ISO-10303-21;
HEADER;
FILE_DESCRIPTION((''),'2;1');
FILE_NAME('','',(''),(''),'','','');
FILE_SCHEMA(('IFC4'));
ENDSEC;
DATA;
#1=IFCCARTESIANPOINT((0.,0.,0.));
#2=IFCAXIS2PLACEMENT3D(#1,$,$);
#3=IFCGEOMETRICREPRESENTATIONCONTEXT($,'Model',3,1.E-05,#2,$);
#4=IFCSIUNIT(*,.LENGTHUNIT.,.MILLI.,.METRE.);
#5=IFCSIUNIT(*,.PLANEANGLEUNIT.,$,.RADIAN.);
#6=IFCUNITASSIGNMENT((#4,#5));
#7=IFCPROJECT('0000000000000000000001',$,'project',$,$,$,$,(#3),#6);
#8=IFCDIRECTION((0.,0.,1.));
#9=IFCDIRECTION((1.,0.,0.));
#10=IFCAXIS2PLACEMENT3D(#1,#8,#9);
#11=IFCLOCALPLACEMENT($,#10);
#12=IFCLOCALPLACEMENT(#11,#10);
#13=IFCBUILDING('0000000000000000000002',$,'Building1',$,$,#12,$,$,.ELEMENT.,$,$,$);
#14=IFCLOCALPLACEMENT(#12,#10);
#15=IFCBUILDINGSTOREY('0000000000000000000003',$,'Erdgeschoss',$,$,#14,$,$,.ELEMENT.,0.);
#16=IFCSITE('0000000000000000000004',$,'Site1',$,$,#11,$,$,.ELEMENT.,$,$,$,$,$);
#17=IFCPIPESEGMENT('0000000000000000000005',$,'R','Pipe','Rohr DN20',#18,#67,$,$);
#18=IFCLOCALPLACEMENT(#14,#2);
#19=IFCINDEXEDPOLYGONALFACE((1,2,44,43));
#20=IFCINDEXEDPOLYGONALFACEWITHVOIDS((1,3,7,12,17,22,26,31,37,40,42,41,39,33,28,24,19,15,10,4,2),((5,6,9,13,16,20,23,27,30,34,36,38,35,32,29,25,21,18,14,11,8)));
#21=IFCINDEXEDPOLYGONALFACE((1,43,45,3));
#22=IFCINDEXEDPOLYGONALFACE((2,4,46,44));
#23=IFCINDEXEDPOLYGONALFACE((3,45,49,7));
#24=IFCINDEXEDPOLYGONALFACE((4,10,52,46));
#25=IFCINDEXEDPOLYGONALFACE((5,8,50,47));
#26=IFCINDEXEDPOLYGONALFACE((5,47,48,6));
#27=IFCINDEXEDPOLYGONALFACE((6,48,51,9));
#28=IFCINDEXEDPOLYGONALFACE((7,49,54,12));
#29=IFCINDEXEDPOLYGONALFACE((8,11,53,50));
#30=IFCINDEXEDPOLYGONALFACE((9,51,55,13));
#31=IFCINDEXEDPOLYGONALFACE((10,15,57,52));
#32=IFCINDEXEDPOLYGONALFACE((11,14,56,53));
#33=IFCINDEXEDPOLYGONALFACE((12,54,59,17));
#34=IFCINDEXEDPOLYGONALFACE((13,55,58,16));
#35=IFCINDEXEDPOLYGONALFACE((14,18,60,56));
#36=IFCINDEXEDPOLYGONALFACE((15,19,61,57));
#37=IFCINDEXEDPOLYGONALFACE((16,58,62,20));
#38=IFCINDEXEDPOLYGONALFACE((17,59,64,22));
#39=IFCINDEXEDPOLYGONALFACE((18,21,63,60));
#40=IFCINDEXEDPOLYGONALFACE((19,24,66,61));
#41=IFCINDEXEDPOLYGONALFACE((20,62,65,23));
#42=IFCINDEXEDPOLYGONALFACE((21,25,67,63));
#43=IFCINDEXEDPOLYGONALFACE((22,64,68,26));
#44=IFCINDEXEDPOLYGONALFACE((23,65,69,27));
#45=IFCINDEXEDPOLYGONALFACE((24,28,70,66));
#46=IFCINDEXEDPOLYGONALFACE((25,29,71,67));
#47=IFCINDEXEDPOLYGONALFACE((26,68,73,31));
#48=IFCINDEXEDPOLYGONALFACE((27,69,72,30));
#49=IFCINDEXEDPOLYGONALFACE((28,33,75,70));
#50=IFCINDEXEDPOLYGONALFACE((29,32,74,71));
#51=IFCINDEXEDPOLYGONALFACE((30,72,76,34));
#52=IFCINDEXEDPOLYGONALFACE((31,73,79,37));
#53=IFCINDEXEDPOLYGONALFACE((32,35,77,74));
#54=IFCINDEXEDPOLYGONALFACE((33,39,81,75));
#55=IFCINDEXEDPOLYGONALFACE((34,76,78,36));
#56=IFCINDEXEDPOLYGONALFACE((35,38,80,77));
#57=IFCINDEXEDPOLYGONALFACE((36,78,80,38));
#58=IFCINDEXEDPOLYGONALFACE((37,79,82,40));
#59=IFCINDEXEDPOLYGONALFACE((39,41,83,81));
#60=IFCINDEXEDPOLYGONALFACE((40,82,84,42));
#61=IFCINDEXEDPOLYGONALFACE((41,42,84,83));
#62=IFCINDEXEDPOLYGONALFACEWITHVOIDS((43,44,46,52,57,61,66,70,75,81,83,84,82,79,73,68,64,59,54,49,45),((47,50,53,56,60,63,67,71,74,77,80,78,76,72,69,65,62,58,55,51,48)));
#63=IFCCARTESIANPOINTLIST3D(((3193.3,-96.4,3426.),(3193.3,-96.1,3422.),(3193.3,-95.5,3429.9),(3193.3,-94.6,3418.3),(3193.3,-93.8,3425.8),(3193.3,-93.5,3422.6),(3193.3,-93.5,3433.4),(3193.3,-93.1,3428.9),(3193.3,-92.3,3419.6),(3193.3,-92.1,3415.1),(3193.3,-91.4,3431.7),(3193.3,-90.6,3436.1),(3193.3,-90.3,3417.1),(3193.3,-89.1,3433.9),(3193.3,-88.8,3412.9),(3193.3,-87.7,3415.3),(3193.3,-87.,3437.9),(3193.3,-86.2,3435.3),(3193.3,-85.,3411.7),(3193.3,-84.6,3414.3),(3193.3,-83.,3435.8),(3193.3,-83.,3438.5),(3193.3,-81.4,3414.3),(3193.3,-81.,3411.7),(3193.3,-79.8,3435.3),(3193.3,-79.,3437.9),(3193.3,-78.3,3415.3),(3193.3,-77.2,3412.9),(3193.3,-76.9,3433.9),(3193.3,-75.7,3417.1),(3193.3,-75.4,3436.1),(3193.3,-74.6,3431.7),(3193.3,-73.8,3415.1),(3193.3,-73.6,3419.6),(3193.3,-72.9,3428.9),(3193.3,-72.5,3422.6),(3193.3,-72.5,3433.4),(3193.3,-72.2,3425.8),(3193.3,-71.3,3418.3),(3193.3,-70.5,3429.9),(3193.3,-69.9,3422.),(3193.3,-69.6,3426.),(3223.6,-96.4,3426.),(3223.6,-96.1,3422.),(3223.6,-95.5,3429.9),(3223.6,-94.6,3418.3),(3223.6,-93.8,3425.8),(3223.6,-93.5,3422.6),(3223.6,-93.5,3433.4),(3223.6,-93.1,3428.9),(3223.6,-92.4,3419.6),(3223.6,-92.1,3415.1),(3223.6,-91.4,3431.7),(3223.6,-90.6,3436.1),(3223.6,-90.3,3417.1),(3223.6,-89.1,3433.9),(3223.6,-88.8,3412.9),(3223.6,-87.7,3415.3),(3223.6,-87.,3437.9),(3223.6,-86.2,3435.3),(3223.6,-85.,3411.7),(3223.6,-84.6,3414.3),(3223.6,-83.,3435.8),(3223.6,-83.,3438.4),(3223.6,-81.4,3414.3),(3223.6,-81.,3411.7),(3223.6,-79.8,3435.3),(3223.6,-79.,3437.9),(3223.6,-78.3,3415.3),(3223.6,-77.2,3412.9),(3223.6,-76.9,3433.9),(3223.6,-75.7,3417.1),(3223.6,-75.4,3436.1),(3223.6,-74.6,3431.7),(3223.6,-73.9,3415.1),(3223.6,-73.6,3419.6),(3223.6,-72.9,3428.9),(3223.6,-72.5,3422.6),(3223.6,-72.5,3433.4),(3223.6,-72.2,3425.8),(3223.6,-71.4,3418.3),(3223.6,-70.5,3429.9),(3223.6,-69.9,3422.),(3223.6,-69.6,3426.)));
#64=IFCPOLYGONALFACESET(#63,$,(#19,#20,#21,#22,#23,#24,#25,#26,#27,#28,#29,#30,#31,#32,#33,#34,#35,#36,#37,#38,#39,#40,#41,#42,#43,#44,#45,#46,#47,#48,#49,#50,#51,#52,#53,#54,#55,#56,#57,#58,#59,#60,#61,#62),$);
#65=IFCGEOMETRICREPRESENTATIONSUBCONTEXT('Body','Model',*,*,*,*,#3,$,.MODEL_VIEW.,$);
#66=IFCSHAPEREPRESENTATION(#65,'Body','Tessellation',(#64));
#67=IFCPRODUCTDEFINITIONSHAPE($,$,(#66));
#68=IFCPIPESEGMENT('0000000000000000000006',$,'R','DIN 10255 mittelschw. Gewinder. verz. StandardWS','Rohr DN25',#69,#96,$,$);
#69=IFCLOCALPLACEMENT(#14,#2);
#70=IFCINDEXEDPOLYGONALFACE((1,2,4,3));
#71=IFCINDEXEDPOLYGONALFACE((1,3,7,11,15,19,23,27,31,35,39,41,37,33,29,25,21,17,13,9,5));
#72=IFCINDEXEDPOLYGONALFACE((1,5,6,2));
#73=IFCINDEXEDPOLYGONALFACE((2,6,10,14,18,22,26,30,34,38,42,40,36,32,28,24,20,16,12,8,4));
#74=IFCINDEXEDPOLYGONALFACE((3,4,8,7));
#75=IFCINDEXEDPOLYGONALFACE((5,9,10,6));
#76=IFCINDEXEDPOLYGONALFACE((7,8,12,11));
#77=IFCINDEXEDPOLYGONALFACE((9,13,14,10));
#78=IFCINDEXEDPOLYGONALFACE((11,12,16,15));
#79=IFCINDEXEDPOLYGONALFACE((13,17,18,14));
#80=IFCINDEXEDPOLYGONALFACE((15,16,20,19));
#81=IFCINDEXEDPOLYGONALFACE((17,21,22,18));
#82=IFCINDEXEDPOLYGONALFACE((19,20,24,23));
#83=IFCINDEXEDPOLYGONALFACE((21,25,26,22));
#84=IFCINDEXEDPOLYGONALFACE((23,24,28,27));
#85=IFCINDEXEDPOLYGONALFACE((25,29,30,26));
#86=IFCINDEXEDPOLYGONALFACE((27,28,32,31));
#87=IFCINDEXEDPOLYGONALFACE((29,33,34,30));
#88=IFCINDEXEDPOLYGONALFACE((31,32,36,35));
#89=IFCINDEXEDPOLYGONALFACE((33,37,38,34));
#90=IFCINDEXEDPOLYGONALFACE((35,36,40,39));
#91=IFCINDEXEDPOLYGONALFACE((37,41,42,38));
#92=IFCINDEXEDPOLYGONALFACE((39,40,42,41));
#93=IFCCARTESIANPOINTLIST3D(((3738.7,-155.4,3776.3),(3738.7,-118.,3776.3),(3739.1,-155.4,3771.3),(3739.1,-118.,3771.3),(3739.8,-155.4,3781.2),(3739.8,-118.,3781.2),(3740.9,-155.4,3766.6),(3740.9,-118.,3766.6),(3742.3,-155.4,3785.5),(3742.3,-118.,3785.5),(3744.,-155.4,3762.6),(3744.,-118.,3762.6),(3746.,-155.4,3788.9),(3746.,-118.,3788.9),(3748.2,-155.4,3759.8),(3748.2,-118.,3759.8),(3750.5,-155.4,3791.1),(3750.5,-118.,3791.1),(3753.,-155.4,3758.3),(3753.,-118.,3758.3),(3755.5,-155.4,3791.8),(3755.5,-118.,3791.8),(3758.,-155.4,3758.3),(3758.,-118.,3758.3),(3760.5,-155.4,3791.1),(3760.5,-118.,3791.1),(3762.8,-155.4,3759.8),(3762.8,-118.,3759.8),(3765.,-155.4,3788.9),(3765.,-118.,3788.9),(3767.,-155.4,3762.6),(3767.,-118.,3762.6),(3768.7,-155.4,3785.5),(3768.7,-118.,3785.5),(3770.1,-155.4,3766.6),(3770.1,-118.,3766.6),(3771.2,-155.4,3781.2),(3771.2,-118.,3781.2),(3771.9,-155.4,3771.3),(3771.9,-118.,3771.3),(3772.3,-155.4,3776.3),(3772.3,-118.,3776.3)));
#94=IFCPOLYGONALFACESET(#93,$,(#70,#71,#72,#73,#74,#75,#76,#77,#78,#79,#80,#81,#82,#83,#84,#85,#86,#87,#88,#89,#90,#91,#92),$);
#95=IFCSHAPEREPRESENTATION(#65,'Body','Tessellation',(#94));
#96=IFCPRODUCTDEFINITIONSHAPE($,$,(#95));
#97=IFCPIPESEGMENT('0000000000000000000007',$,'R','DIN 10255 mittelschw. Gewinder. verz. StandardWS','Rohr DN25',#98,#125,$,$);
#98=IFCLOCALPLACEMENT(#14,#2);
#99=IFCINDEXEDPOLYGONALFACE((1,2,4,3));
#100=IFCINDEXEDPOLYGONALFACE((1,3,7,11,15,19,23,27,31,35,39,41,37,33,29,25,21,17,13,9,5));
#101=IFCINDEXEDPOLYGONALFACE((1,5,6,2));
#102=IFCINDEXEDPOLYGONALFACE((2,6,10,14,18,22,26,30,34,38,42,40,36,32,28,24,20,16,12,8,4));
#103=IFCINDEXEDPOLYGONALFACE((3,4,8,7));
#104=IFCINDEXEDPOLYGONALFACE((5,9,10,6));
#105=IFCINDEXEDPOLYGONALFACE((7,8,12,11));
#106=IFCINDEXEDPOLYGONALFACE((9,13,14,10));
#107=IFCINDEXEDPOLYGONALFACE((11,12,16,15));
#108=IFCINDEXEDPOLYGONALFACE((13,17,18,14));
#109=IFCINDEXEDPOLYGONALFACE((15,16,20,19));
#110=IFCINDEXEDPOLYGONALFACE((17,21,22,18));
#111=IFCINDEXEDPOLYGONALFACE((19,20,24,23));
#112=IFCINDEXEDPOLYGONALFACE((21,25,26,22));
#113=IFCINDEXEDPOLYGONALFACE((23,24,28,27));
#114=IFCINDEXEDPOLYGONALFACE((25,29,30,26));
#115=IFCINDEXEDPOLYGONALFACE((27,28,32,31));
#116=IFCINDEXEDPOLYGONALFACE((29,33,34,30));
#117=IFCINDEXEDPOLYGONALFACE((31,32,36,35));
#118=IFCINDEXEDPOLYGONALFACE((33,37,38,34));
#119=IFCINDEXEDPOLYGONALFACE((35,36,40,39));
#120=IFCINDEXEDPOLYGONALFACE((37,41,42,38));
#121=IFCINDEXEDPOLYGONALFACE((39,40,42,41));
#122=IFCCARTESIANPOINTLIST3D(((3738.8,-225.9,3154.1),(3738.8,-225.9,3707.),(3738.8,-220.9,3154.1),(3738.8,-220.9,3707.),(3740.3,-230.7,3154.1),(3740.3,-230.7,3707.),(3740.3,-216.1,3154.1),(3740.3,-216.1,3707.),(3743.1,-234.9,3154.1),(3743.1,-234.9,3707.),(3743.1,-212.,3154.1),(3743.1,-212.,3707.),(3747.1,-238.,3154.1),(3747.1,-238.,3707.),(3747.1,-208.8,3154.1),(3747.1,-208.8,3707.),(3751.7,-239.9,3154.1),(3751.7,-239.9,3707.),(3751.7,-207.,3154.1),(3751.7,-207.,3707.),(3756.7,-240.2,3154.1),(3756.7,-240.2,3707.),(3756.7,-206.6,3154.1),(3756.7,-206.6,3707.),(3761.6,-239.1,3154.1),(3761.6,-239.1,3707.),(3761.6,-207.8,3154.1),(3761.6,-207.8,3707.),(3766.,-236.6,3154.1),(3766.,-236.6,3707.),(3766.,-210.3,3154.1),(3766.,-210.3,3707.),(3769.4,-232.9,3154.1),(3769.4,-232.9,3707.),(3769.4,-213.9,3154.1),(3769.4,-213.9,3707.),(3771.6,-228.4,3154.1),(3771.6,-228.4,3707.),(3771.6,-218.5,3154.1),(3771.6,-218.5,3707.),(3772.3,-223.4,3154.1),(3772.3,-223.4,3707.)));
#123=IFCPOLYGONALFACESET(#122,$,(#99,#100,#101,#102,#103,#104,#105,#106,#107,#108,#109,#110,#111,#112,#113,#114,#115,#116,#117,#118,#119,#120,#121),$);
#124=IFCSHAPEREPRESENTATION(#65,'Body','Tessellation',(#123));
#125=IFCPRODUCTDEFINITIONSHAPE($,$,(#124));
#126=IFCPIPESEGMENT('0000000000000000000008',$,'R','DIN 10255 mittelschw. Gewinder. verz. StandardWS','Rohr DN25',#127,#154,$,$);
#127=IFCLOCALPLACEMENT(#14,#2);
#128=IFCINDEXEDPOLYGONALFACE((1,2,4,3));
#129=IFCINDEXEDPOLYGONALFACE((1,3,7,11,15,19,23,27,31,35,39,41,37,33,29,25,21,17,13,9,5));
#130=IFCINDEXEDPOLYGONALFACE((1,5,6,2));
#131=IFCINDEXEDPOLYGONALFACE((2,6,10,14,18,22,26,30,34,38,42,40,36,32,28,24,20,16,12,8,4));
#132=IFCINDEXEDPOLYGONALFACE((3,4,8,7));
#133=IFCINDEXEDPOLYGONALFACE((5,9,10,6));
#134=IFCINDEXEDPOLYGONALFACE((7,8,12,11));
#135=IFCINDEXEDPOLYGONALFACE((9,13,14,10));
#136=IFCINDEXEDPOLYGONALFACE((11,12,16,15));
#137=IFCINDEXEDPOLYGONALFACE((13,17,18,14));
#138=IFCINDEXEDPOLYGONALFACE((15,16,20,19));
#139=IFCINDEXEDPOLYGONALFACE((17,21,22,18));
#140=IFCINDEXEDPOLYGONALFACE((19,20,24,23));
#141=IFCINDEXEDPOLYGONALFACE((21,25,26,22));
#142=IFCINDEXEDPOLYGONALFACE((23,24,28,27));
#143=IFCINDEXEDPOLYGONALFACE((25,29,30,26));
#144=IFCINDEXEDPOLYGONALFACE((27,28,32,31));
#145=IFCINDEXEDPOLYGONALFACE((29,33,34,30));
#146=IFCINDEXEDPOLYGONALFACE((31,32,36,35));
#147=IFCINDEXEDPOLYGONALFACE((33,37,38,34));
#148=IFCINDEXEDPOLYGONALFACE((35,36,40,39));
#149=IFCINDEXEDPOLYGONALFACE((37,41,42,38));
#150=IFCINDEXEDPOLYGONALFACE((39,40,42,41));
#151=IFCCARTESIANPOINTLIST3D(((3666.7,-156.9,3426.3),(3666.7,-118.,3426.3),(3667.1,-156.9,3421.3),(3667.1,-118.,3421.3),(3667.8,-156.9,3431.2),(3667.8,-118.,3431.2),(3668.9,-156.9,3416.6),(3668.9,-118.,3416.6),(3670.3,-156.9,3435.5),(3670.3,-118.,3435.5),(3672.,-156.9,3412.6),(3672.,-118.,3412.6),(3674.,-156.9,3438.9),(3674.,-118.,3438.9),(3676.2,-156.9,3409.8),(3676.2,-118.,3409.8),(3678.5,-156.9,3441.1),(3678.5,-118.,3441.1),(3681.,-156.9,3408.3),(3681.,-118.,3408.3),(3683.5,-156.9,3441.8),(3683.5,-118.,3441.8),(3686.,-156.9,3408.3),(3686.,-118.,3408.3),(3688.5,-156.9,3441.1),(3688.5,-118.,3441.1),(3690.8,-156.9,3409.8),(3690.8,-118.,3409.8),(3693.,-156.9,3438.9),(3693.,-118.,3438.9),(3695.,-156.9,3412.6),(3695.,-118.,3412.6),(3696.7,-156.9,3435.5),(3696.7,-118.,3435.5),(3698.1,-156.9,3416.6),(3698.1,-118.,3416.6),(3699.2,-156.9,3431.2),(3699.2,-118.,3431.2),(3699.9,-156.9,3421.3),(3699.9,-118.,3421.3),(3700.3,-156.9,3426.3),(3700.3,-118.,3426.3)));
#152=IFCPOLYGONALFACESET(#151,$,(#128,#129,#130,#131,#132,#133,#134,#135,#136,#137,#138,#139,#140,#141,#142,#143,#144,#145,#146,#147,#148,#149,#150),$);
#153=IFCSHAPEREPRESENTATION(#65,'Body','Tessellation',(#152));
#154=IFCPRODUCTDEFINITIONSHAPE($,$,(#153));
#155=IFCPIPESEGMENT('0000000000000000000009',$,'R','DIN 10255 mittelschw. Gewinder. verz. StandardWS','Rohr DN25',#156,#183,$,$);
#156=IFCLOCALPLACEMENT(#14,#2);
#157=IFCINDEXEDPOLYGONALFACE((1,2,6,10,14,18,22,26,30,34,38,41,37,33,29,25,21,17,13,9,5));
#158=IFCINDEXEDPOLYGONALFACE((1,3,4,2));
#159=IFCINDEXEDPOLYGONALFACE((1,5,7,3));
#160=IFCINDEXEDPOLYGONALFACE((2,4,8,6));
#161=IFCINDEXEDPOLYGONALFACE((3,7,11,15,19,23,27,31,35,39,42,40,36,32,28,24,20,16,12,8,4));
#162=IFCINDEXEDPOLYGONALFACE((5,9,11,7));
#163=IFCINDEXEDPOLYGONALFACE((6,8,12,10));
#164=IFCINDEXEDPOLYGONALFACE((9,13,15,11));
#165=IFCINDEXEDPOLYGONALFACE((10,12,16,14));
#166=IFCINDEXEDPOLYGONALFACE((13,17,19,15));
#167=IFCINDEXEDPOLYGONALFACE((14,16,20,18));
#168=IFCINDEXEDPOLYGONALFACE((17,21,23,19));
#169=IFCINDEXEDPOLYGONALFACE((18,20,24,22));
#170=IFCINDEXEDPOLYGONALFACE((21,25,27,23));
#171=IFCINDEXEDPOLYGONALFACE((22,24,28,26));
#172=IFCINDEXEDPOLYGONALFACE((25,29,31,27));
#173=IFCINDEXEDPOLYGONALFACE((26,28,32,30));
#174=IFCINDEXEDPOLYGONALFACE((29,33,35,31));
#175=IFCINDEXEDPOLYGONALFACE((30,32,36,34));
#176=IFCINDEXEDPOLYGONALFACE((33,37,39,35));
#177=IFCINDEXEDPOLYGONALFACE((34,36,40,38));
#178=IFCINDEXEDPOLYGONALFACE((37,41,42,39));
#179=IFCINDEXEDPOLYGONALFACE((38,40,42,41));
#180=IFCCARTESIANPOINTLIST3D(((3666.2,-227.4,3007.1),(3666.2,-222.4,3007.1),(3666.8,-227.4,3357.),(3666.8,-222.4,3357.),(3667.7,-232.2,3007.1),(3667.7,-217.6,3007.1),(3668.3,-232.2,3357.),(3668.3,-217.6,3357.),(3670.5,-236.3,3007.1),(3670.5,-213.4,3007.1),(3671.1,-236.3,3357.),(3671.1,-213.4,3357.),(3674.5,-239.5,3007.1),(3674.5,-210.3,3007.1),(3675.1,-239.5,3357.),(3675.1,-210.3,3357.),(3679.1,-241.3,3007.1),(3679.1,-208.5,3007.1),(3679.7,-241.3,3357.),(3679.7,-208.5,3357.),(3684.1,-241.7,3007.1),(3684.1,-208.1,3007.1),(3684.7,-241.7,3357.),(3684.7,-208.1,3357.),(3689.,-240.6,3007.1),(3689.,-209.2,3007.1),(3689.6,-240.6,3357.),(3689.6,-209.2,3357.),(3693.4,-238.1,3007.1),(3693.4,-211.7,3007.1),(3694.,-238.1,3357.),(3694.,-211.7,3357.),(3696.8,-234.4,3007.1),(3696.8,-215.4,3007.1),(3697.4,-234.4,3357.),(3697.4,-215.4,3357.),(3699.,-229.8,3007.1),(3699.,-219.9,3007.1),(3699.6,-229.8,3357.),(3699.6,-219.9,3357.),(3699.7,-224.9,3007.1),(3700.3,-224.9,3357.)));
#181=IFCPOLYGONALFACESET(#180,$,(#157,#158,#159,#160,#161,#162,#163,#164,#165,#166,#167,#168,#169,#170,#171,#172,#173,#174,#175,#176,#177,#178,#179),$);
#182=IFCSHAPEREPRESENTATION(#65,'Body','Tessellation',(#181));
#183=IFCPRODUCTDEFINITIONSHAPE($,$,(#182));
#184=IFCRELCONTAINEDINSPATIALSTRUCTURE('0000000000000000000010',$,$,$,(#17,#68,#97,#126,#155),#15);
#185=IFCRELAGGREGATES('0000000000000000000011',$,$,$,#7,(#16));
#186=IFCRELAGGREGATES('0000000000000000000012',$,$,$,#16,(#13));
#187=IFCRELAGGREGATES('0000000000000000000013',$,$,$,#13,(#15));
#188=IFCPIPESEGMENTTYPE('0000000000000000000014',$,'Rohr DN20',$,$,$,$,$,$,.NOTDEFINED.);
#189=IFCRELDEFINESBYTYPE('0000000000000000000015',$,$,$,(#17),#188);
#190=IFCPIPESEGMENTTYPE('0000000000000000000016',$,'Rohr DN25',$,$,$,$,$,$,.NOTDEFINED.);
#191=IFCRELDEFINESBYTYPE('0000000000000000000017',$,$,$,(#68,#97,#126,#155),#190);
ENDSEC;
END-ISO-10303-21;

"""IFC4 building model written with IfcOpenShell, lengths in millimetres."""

from ifc_helpers import new_model, si_unit, frame, origin, origin_with_axes, origin_2d_with_axis, place, context, subcontext, project, spatial, circle, hollow_circle, extrude, type_object, element, save


model = new_model("IFC4")

# Units and contexts
model_context = context("Model", 3, precision=1e-05, world=origin())
body_context = subcontext(model_context, "Body", "Model", "MODEL_VIEW")
ifc_project = project(units=[si_unit("LENGTHUNIT", "METRE", prefix="MILLI"), si_unit("PLANEANGLEUNIT", "RADIAN")], contexts=[model_context])

# Site, building, storey
site_placement = place(None, origin_with_axes())
site = spatial("IfcSite", under=ifc_project, at=site_placement, Name="Site1", CompositionType="ELEMENT")
building_placement = place(site_placement, origin_with_axes())
building = spatial("IfcBuilding", under=site, at=building_placement, Name="Building1", CompositionType="ELEMENT")
storey_placement = place(building_placement, origin_with_axes())
storey = spatial("IfcBuildingStorey", under=building, at=storey_placement, Name="Erdgeschoss", CompositionType="ELEMENT", Elevation=0.0)

# Pipe segments
pipe_segment_type_1 = type_object("IfcPipeSegmentType", Name="Rohr DN20", PredefinedType="NOTDEFINED")
pipe_segment_1_placement = place(storey_placement, frame((3208.4, -82.8, 3425.0), z_axis=(0.0, 0.0, 1.0), x_axis=(1.0, 0.0, 0.0)))
element("IfcPipeSegment", 1, at=pipe_segment_1_placement, inside=storey, type_object=pipe_segment_type_1, Name="R", Description="Pipe", ObjectType="Rohr DN20", context=body_context, shape_type="SolidModel", body=[
    extrude(hollow_circle(Radius=13.4, WallThickness=2.6, at=origin_2d_with_axis()), frame((-15.2, -0.1, 0.0), z_axis=(1.0, -0.000108, -0.000078), x_axis=(0.0, 0.0, 1.0)), (0.0, 0.0, 1.0), 30.3),
])
pipe_segment_type_2 = type_object("IfcPipeSegmentType", Name="Rohr DN25", PredefinedType="NOTDEFINED")
pipe_segment_2_placement = place(storey_placement, frame((3755.6, -136.7, 3775.0), z_axis=(0.0, 0.0, 1.0), x_axis=(1.0, 0.0, 0.0)))
element("IfcPipeSegment", 2, at=pipe_segment_2_placement, inside=storey, type_object=pipe_segment_type_2, Name="R", Description="DIN 10255 mittelschw. Gewinder. verz. StandardWS", ObjectType="Rohr DN25", context=body_context, shape_type="SolidModel", body=[
    extrude(circle(Radius=16.9, at=origin_2d_with_axis()), frame((-0.1, 18.7, 0.0), z_axis=(0.0, -1.0, 0.0), x_axis=(0.0, 0.0, 1.0)), (0.0, 0.0, 1.0), 37.4),
])
pipe_segment_3_placement = place(storey_placement, frame((3755.5, -223.3, 3430.6), z_axis=(0.0, 0.0, 1.0), x_axis=(1.0, 0.0, 0.0)))
element("IfcPipeSegment", 3, at=pipe_segment_3_placement, inside=storey, type_object=pipe_segment_type_2, Name="R", Description="DIN 10255 mittelschw. Gewinder. verz. StandardWS", ObjectType="Rohr DN25", context=body_context, shape_type="SolidModel", body=[
    extrude(circle(Radius=16.9, at=origin_2d_with_axis()), frame((0.0, -0.2, 276.4), z_axis=(0.0, 0.0, -1.0), x_axis=(1.0, 0.0, 0.0)), (0.0, 0.0, 1.0), 552.9),
])
pipe_segment_4_placement = place(storey_placement, frame((3683.6, -137.4, 3425.0), z_axis=(0.0, 0.0, 1.0), x_axis=(1.0, 0.0, 0.0)))
element("IfcPipeSegment", 4, at=pipe_segment_4_placement, inside=storey, type_object=pipe_segment_type_2, Name="R", Description="DIN 10255 mittelschw. Gewinder. verz. StandardWS", ObjectType="Rohr DN25", context=body_context, shape_type="SolidModel", body=[
    extrude(circle(Radius=16.9, at=origin_2d_with_axis()), frame((-0.2, 19.4, 0.0), z_axis=(0.0, -1.0, 0.0), x_axis=(0.0, 0.0, 1.0)), (0.0, 0.0, 1.0), 38.9),
])
pipe_segment_5_placement = place(storey_placement, frame((3683.2, -225.0, 3182.1), z_axis=(0.0, 0.0, 1.0), x_axis=(1.0, 0.0, 0.0)))
element("IfcPipeSegment", 5, at=pipe_segment_5_placement, inside=storey, type_object=pipe_segment_type_2, Name="R", Description="DIN 10255 mittelschw. Gewinder. verz. StandardWS", ObjectType="Rohr DN25", context=body_context, shape_type="SolidModel", body=[
    extrude(circle(Radius=16.9, at=origin_2d_with_axis()), frame((0.3, 0.2, 174.9), z_axis=(-0.00173, 0.0, -0.999999), x_axis=(1.0, 0.0, 0.0)), (0.0, 0.0, 1.0), 349.9),
])

save(model, "model.ifc")
